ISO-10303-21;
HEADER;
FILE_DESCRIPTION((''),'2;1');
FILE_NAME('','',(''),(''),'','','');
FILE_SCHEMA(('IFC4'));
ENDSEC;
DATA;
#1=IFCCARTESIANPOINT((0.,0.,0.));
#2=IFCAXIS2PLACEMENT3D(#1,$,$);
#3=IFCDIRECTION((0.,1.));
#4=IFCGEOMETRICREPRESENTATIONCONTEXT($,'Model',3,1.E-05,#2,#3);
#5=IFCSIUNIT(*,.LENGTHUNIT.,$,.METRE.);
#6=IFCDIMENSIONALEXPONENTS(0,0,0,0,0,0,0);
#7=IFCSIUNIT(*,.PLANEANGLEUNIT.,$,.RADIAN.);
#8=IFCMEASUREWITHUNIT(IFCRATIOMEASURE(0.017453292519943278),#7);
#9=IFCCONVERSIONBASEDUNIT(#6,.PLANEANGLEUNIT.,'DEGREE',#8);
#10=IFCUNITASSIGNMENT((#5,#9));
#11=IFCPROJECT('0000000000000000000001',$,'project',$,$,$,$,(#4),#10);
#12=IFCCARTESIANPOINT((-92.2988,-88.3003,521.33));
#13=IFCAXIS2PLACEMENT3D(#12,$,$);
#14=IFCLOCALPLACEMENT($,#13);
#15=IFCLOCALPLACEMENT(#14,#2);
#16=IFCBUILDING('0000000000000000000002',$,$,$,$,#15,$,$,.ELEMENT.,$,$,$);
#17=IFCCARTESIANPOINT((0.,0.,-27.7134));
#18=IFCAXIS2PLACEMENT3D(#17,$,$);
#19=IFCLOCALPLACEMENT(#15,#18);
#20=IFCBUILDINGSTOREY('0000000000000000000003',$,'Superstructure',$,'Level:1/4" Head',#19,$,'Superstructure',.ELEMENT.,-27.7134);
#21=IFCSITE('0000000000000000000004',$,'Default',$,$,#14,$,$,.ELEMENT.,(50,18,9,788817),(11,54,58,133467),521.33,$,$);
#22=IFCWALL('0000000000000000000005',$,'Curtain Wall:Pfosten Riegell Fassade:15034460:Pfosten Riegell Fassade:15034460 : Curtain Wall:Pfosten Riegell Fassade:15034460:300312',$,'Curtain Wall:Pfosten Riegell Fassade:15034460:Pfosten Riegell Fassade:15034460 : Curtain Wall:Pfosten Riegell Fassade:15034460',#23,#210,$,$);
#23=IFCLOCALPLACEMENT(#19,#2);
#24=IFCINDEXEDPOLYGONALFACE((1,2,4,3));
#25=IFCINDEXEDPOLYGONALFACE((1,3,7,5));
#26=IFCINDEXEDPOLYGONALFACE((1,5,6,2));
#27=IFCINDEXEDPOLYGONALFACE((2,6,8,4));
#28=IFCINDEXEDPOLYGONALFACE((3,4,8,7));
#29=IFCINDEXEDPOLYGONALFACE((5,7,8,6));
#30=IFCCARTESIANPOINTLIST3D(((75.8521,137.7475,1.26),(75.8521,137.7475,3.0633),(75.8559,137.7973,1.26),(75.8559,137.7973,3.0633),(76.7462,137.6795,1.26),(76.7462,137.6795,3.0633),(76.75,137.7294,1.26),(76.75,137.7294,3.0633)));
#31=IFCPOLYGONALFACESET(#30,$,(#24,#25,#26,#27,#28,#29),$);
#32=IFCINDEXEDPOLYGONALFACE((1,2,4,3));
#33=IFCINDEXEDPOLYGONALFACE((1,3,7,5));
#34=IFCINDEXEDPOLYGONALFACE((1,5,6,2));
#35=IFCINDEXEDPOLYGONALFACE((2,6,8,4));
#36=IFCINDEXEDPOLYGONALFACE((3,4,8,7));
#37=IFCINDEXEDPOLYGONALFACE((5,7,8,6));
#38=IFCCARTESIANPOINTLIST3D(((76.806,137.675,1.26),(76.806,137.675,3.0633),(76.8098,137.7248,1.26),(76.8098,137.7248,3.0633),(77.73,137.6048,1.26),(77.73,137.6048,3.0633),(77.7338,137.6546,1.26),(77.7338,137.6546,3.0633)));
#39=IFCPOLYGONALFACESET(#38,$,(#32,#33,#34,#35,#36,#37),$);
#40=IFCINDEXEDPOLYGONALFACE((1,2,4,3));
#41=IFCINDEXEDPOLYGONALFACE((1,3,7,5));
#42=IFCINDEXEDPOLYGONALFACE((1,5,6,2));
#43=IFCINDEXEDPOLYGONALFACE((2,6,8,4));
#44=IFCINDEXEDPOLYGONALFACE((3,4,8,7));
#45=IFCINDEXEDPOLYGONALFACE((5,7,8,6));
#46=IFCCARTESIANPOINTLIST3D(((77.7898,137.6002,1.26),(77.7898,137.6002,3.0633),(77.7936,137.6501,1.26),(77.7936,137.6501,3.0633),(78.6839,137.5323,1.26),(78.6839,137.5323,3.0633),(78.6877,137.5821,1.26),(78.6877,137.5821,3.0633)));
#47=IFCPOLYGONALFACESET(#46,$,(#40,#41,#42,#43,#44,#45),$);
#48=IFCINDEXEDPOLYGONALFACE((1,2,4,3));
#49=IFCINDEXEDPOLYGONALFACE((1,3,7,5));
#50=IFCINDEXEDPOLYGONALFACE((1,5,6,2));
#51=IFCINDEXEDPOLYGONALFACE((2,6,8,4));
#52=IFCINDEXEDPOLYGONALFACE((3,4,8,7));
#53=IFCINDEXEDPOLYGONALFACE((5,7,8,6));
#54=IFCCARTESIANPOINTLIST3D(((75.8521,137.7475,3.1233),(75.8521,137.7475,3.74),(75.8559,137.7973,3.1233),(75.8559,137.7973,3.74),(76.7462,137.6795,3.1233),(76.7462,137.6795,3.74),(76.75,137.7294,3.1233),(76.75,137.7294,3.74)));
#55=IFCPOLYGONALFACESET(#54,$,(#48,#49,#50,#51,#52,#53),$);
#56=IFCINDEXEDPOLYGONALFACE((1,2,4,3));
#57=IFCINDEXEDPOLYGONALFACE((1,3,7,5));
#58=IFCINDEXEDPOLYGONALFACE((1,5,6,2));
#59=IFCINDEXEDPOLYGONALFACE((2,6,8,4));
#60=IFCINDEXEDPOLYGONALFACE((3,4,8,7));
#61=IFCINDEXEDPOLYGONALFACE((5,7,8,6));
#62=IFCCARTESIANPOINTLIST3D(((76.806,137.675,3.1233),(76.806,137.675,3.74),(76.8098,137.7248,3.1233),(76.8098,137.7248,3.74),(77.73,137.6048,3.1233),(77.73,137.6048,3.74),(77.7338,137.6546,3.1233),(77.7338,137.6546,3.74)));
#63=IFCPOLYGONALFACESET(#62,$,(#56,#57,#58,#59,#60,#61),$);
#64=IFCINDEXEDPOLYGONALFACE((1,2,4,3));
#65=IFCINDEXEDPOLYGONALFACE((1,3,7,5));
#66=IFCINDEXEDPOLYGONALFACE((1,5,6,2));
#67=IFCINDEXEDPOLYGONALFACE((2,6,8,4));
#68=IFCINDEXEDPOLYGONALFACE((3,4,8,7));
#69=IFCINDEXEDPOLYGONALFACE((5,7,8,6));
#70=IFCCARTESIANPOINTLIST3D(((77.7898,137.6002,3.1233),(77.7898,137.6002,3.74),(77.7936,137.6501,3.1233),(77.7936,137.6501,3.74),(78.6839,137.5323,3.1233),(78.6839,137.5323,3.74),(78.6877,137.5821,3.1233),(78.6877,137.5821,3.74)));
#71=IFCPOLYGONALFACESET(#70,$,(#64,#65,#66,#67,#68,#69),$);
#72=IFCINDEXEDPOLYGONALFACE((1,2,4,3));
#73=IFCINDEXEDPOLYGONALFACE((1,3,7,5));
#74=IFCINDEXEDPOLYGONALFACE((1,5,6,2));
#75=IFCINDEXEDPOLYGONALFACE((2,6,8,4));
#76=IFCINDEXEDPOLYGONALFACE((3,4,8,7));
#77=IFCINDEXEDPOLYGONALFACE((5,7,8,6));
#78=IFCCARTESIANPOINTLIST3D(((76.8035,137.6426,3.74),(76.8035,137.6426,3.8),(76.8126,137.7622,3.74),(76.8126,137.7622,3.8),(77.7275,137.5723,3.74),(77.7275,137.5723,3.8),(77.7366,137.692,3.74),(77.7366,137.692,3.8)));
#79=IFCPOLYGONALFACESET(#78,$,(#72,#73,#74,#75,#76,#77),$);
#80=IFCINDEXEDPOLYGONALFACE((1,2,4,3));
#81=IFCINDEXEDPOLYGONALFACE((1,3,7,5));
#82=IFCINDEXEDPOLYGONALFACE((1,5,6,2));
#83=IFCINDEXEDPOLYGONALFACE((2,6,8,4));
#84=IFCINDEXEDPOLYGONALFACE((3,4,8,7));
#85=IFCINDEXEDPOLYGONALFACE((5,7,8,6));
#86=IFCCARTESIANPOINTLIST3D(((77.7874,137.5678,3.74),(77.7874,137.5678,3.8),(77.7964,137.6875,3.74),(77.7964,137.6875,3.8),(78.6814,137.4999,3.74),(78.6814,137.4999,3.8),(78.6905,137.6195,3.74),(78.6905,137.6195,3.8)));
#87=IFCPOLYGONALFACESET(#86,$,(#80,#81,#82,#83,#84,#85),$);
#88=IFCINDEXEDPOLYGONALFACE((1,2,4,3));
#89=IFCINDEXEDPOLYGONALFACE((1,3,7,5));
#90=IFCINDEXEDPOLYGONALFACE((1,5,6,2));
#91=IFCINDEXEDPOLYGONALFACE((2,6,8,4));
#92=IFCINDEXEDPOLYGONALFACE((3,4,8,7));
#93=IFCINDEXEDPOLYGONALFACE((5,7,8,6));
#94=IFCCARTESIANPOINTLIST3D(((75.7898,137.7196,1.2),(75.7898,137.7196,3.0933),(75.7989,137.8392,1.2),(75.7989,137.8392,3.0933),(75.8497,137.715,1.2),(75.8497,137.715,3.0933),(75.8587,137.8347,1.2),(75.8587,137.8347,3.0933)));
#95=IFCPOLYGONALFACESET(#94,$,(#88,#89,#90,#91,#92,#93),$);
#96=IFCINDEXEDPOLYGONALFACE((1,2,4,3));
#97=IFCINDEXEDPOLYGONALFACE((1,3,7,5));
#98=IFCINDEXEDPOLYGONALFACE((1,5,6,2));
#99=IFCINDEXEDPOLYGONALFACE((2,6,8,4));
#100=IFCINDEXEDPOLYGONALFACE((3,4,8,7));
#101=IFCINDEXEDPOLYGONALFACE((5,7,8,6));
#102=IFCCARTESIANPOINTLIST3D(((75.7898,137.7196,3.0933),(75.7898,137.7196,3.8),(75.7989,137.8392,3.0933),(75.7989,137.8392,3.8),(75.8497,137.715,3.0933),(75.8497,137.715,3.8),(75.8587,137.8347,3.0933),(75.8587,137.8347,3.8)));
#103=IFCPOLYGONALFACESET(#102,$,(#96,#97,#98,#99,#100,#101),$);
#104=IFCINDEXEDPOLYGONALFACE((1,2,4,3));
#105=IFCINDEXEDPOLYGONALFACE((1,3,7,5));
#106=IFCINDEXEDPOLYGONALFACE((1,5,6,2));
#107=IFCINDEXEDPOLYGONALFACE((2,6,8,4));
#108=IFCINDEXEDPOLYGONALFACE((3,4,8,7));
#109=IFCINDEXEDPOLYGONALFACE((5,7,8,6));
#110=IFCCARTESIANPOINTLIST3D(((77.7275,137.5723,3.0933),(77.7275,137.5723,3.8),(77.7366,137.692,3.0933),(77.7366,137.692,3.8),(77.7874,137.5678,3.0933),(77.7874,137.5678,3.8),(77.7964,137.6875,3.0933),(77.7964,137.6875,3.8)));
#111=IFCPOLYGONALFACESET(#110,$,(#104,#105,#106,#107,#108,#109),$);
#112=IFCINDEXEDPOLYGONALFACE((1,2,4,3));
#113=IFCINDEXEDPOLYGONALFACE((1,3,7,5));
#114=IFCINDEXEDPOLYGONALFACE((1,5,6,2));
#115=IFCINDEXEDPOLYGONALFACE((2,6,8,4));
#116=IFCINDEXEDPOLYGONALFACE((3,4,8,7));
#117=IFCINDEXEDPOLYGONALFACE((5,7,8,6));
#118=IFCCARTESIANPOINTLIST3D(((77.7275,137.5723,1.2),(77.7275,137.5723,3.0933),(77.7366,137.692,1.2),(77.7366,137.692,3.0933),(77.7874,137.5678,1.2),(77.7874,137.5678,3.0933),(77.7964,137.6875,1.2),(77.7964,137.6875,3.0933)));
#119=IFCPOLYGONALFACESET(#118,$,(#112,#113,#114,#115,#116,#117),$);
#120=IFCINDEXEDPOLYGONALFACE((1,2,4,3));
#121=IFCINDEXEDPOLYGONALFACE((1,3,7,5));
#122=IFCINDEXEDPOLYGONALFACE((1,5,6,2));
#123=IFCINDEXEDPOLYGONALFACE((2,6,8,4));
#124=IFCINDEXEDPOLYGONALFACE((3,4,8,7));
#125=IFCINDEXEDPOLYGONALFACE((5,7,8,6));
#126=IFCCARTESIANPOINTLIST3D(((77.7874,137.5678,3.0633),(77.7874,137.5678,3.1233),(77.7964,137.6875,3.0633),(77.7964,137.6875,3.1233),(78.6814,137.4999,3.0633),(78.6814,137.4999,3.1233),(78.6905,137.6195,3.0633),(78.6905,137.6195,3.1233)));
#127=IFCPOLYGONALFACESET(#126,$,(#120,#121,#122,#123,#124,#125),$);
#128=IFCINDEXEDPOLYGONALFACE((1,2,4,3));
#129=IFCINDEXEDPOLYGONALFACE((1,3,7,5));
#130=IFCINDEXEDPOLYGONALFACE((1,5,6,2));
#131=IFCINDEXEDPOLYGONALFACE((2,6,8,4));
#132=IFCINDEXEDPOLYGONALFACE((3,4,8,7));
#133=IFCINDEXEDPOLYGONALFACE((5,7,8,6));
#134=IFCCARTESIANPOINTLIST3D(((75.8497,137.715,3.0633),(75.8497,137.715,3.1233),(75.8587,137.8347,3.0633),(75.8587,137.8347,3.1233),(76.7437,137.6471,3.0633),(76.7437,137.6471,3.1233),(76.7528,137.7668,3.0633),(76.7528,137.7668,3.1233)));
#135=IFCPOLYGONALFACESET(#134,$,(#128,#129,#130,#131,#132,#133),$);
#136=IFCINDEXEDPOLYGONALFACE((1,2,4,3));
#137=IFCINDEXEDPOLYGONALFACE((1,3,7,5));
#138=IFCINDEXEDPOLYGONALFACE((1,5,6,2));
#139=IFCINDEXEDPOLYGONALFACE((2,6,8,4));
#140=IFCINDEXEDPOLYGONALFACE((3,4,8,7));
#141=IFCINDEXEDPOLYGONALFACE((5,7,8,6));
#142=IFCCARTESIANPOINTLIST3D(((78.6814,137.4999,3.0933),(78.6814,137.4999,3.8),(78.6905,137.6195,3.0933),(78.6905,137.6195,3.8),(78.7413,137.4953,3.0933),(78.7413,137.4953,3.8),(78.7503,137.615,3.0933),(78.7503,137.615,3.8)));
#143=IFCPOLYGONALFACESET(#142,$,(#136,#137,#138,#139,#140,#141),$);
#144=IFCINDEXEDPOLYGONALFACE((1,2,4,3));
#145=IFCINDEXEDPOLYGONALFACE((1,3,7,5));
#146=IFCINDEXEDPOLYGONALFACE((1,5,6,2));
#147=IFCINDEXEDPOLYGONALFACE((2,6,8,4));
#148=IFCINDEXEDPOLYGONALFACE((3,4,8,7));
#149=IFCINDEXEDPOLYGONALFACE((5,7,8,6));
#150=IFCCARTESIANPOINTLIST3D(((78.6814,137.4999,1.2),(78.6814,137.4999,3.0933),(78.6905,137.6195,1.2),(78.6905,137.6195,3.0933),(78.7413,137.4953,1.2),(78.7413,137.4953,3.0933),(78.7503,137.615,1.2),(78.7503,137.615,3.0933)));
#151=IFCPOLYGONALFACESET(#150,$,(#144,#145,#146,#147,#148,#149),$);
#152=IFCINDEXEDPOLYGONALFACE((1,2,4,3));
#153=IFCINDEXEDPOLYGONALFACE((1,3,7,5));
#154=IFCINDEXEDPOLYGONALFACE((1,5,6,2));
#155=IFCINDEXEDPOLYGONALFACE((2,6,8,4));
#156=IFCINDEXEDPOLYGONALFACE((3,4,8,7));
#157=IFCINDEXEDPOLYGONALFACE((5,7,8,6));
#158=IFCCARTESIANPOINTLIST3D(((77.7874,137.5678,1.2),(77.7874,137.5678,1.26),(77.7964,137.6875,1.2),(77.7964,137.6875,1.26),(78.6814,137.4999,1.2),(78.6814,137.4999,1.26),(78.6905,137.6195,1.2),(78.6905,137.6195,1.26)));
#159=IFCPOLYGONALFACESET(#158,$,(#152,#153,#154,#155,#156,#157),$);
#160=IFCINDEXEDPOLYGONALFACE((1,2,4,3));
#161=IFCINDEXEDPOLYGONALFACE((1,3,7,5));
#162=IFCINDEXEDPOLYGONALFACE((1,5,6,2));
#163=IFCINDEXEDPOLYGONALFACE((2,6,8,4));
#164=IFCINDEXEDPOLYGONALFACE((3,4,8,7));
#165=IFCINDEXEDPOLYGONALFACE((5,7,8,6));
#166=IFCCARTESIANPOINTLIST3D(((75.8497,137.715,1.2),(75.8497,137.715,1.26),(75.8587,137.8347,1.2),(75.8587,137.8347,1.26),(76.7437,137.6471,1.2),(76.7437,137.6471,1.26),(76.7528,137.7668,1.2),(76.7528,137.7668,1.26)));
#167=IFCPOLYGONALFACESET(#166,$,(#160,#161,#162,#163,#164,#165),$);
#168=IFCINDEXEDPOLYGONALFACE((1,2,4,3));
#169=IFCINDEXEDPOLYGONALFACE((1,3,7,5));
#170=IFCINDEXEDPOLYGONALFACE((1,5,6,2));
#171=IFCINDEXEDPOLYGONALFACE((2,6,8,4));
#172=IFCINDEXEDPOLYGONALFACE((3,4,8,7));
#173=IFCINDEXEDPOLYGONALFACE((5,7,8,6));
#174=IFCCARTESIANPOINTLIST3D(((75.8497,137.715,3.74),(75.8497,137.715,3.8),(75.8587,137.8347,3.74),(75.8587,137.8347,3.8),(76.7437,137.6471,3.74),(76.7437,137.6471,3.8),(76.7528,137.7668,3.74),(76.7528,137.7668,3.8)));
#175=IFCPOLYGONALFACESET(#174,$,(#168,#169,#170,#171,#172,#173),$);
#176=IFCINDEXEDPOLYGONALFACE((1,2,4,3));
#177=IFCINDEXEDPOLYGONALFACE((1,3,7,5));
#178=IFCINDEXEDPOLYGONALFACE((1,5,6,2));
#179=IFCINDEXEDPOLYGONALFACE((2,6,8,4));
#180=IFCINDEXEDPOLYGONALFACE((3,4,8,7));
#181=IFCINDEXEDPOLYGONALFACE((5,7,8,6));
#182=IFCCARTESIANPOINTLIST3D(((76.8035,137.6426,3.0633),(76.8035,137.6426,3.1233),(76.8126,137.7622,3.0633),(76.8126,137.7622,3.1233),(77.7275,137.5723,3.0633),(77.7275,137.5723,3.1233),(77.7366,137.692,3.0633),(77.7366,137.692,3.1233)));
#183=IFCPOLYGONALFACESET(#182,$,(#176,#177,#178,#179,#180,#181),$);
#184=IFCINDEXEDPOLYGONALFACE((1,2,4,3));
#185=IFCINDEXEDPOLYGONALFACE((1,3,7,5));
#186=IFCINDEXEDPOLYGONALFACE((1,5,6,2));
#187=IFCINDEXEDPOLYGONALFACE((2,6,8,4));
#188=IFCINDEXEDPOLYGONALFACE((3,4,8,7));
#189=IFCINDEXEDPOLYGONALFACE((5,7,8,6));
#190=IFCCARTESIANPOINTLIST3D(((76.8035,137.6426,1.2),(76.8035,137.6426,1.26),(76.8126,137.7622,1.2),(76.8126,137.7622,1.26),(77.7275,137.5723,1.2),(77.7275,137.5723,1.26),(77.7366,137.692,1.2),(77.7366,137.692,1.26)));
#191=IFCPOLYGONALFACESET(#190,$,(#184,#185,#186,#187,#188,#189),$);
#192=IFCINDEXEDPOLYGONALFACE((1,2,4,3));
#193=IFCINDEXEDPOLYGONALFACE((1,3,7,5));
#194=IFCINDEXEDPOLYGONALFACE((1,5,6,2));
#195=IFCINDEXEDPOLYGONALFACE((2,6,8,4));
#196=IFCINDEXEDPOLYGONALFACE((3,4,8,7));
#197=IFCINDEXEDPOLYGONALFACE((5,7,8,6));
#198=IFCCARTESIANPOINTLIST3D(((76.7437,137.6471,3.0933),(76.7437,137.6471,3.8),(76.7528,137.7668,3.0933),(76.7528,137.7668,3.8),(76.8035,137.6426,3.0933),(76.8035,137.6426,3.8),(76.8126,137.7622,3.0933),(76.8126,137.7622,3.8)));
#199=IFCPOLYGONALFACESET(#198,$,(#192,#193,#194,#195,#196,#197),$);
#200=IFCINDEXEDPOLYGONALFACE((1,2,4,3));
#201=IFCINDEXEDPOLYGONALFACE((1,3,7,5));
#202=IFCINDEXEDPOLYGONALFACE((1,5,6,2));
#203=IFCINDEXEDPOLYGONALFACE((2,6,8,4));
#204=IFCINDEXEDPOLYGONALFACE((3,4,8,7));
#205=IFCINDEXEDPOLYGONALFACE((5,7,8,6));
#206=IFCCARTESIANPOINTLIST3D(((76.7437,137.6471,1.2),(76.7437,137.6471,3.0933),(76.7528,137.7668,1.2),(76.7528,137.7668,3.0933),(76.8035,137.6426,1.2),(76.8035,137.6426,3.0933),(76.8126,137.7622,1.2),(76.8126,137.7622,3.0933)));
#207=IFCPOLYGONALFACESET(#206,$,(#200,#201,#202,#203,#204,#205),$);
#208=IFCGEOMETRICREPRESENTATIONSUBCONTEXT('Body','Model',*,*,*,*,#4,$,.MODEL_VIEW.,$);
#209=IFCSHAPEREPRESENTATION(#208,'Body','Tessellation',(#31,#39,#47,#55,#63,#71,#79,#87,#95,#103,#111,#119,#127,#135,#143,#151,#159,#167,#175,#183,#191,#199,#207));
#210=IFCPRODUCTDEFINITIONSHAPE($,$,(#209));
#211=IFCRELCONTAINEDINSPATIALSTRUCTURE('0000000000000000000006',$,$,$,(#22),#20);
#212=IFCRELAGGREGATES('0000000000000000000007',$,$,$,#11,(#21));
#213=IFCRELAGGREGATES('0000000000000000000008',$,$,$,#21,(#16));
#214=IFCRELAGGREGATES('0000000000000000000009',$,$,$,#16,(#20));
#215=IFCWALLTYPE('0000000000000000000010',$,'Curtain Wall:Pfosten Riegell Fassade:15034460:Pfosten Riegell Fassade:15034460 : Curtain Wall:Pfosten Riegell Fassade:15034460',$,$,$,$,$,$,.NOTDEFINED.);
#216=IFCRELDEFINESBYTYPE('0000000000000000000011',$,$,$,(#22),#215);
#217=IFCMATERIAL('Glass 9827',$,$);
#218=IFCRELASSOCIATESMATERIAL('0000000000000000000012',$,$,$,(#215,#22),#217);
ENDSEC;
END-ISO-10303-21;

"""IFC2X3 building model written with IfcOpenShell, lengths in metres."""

from ifc_helpers import new_model, entity, si_unit, converted_unit, direction, frame, frame_2d, origin, origin_2d_with_axis, place, context, subcontext, project, spatial, rectangle, extrude, material, type_object, element, save


model = new_model("IFC2X3")

# Units and contexts
model_context = context("Model", 3, precision=1e-05, world=origin(), true_north=direction((0.0, 1.0)))
body_context = subcontext(model_context, "Body", "Model", "MODEL_VIEW")
ifc_project = project(units=[si_unit("LENGTHUNIT", "METRE"), converted_unit("PLANEANGLEUNIT", "DEGREE", entity("IfcRatioMeasure", 0.017453292519943278), si_unit("PLANEANGLEUNIT", "RADIAN"), dimensions=[0, 0, 0, 0, 0, 0, 0])], contexts=[model_context])

# Site, building, storey
site_placement = place(None, frame((-92.2988, -88.3003, 521.33)))
site = spatial("IfcSite", under=ifc_project, at=site_placement, Name="Default", CompositionType="ELEMENT", RefLatitude=(50, 18, 9, 788817), RefLongitude=(11, 54, 58, 133467), RefElevation=521.33)
building_placement = place(site_placement, origin())
building = spatial("IfcBuilding", under=site, at=building_placement, CompositionType="ELEMENT")
storey_placement = place(building_placement, frame((0.0, 0.0, -27.7134)))
storey = spatial("IfcBuildingStorey", under=building, at=storey_placement, Name="Superstructure", ObjectType="Level:1/4\" Head", LongName="Superstructure", CompositionType="ELEMENT", Elevation=-27.7134)

# Wall
ifc_material_1 = material(Name="Glass 9827")
wall_type_1 = type_object("IfcWallType", Name="Curtain Wall:Pfosten Riegell Fassade:15034460:Pfosten Riegell Fassade:15034460 : Curtain Wall:Pfosten Riegell Fassade:15034460", PredefinedType="NOTDEFINED", material=ifc_material_1)
wall_1_placement = place(storey_placement, frame((75.7898, 137.4953, 1.2)))
element("IfcWall", 1, at=wall_1_placement, inside=storey, type_object=wall_type_1, material=ifc_material_1, Name="Curtain Wall:Pfosten Riegell Fassade:15034460:Pfosten Riegell Fassade:15034460 : Curtain Wall:Pfosten Riegell Fassade:15034460:300312", ObjectType="Curtain Wall:Pfosten Riegell Fassade:15034460:Pfosten Riegell Fassade:15034460 : Curtain Wall:Pfosten Riegell Fassade:15034460", context=body_context, shape_type="SweptSolid", body=[
    extrude(rectangle(XDim=0.8966, YDim=0.05, at=frame_2d((0.0, 0.0), x_axis=(1.0, 0.0))), frame((0.5112, 0.2431, 0.06), z_axis=(0.0, 0.0, 1.0), x_axis=(-0.997125, 0.07577, 0.0)), (0.0, 0.0, 1.0), 1.8033),
    extrude(rectangle(XDim=0.9266, YDim=0.05, at=frame_2d((0.0, 0.0), x_axis=(1.0, 0.0))), frame((1.4801, 0.1695, 0.06), z_axis=(0.0, 0.0, 1.0), x_axis=(-0.997125, 0.07577, 0.0)), (0.0, 0.0, 1.0), 1.8033),
    extrude(rectangle(XDim=0.8966, YDim=0.05, at=frame_2d((0.0, 0.0), x_axis=(1.0, 0.0))), frame((2.4489, 0.0959, 0.06), z_axis=(0.0, 0.0, 1.0), x_axis=(-0.997125, 0.07577, 0.0)), (0.0, 0.0, 1.0), 1.8033),
    extrude(rectangle(XDim=0.8966, YDim=0.05, at=frame_2d((0.0, 0.0), x_axis=(1.0, 0.0))), frame((0.5112, 0.2431, 1.9233), z_axis=(0.0, 0.0, 1.0), x_axis=(-0.997125, 0.07577, 0.0)), (0.0, 0.0, 1.0), 0.6167),
    extrude(rectangle(XDim=0.9266, YDim=0.05, at=frame_2d((0.0, 0.0), x_axis=(1.0, 0.0))), frame((1.4801, 0.1695, 1.9233), z_axis=(0.0, 0.0, 1.0), x_axis=(-0.997125, 0.07577, 0.0)), (0.0, 0.0, 1.0), 0.6167),
    extrude(rectangle(XDim=0.8966, YDim=0.05, at=frame_2d((0.0, 0.0), x_axis=(1.0, 0.0))), frame((2.4489, 0.0959, 1.9233), z_axis=(0.0, 0.0, 1.0), x_axis=(-0.997125, 0.07577, 0.0)), (0.0, 0.0, 1.0), 0.6167),
    extrude(rectangle(XDim=0.9266, YDim=0.12, at=frame_2d((0.0, 0.0), x_axis=(1.0, 0.0))), frame((1.4803, 0.172, 2.54), z_axis=(0.0, 0.0, 1.0), x_axis=(-0.997125, 0.07577, 0.0)), (0.0, 0.0, 1.0), 0.06),
    extrude(rectangle(XDim=0.8966, YDim=0.12, at=frame_2d((0.0, 0.0), x_axis=(1.0, 0.0))), frame((2.4491, 0.0983, 2.54), z_axis=(0.0, 0.0, 1.0), x_axis=(-0.997125, 0.07577, 0.0)), (0.0, 0.0, 1.0), 0.06),
    extrude(rectangle(XDim=0.12, YDim=0.06, at=frame_2d((0.0, 0.0), x_axis=(1.0, 0.0))), frame((0.0345, 0.2818, 0.0), z_axis=(0.0, 0.0, 1.0), x_axis=(0.07577, 0.997125, 0.0)), (0.0, 0.0, 1.0), 1.8933),
    extrude(rectangle(XDim=0.12, YDim=0.06, at=frame_2d((0.0, 0.0), x_axis=(1.0, 0.0))), frame((0.0345, 0.2818, 1.8933), z_axis=(0.0, 0.0, 1.0), x_axis=(0.07577, 0.997125, 0.0)), (0.0, 0.0, 1.0), 0.7067),
    extrude(rectangle(XDim=0.06, YDim=0.12, at=origin_2d_with_axis()), frame((1.9722, 0.1346, 1.8933), z_axis=(0.0, 0.0, 1.0), x_axis=(0.997125, -0.07577, 0.0)), (0.0, 0.0, 1.0), 0.7067),
    extrude(rectangle(XDim=0.06, YDim=0.12, at=origin_2d_with_axis()), frame((1.9722, 0.1346, 0.0), z_axis=(0.0, 0.0, 1.0), x_axis=(0.997125, -0.07577, 0.0)), (0.0, 0.0, 1.0), 1.8933),
    extrude(rectangle(XDim=0.8966, YDim=0.12, at=frame_2d((0.0, 0.0), x_axis=(1.0, 0.0))), frame((2.4491, 0.0983, 1.8633), z_axis=(0.0, 0.0, 1.0), x_axis=(-0.997125, 0.07577, 0.0)), (0.0, 0.0, 1.0), 0.06),
    extrude(rectangle(XDim=0.8966, YDim=0.12, at=frame_2d((0.0, 0.0), x_axis=(1.0, 0.0))), frame((0.5114, 0.2456, 1.8633), z_axis=(0.0, 0.0, 1.0), x_axis=(-0.997125, 0.07577, 0.0)), (0.0, 0.0, 1.0), 0.06),
    extrude(rectangle(XDim=0.06, YDim=0.12, at=origin_2d_with_axis()), frame((2.9261, 0.0621, 1.8933), z_axis=(0.0, 0.0, 1.0), x_axis=(0.997125, -0.07577, 0.0)), (0.0, 0.0, 1.0), 0.7067),
    extrude(rectangle(XDim=0.06, YDim=0.12, at=origin_2d_with_axis()), frame((2.9261, 0.0621, 0.0), z_axis=(0.0, 0.0, 1.0), x_axis=(0.997125, -0.07577, 0.0)), (0.0, 0.0, 1.0), 1.8933),
    extrude(rectangle(XDim=0.8966, YDim=0.12, at=frame_2d((0.0, 0.0), x_axis=(1.0, 0.0))), frame((2.4491, 0.0983, 0.0), z_axis=(0.0, 0.0, 1.0), x_axis=(0.997125, -0.07577, 0.0)), (0.0, 0.0, 1.0), 0.06),
    extrude(rectangle(XDim=0.8966, YDim=0.12, at=frame_2d((0.0, 0.0), x_axis=(1.0, 0.0))), frame((0.5114, 0.2456, 0.0), z_axis=(0.0, 0.0, 1.0), x_axis=(0.997125, -0.07577, 0.0)), (0.0, 0.0, 1.0), 0.06),
    extrude(rectangle(XDim=0.8966, YDim=0.12, at=frame_2d((0.0, 0.0), x_axis=(1.0, 0.0))), frame((0.5114, 0.2456, 2.54), z_axis=(0.0, 0.0, 1.0), x_axis=(-0.997125, 0.07577, 0.0)), (0.0, 0.0, 1.0), 0.06),
    extrude(rectangle(XDim=0.9266, YDim=0.12, at=frame_2d((0.0, 0.0), x_axis=(1.0, 0.0))), frame((1.4803, 0.172, 1.8633), z_axis=(0.0, 0.0, 1.0), x_axis=(-0.997125, 0.07577, 0.0)), (0.0, 0.0, 1.0), 0.06),
    extrude(rectangle(XDim=0.9266, YDim=0.12, at=frame_2d((0.0, 0.0), x_axis=(1.0, 0.0))), frame((1.4803, 0.172, 0.0), z_axis=(0.0, 0.0, 1.0), x_axis=(0.997125, -0.07577, 0.0)), (0.0, 0.0, 1.0), 0.06),
    extrude(rectangle(XDim=0.06, YDim=0.12, at=frame_2d((0.0, 0.0), x_axis=(1.0, 0.0))), frame((0.9884, 0.2093, 1.8933), z_axis=(0.0, 0.0, 1.0), x_axis=(0.997125, -0.07577, 0.0)), (0.0, 0.0, 1.0), 0.7067),
    extrude(rectangle(XDim=0.06, YDim=0.12, at=frame_2d((0.0, 0.0), x_axis=(1.0, 0.0))), frame((0.9884, 0.2093, 0.0), z_axis=(0.0, 0.0, 1.0), x_axis=(0.997125, -0.07577, 0.0)), (0.0, 0.0, 1.0), 1.8933),
])

save(model, "model.ifc")
